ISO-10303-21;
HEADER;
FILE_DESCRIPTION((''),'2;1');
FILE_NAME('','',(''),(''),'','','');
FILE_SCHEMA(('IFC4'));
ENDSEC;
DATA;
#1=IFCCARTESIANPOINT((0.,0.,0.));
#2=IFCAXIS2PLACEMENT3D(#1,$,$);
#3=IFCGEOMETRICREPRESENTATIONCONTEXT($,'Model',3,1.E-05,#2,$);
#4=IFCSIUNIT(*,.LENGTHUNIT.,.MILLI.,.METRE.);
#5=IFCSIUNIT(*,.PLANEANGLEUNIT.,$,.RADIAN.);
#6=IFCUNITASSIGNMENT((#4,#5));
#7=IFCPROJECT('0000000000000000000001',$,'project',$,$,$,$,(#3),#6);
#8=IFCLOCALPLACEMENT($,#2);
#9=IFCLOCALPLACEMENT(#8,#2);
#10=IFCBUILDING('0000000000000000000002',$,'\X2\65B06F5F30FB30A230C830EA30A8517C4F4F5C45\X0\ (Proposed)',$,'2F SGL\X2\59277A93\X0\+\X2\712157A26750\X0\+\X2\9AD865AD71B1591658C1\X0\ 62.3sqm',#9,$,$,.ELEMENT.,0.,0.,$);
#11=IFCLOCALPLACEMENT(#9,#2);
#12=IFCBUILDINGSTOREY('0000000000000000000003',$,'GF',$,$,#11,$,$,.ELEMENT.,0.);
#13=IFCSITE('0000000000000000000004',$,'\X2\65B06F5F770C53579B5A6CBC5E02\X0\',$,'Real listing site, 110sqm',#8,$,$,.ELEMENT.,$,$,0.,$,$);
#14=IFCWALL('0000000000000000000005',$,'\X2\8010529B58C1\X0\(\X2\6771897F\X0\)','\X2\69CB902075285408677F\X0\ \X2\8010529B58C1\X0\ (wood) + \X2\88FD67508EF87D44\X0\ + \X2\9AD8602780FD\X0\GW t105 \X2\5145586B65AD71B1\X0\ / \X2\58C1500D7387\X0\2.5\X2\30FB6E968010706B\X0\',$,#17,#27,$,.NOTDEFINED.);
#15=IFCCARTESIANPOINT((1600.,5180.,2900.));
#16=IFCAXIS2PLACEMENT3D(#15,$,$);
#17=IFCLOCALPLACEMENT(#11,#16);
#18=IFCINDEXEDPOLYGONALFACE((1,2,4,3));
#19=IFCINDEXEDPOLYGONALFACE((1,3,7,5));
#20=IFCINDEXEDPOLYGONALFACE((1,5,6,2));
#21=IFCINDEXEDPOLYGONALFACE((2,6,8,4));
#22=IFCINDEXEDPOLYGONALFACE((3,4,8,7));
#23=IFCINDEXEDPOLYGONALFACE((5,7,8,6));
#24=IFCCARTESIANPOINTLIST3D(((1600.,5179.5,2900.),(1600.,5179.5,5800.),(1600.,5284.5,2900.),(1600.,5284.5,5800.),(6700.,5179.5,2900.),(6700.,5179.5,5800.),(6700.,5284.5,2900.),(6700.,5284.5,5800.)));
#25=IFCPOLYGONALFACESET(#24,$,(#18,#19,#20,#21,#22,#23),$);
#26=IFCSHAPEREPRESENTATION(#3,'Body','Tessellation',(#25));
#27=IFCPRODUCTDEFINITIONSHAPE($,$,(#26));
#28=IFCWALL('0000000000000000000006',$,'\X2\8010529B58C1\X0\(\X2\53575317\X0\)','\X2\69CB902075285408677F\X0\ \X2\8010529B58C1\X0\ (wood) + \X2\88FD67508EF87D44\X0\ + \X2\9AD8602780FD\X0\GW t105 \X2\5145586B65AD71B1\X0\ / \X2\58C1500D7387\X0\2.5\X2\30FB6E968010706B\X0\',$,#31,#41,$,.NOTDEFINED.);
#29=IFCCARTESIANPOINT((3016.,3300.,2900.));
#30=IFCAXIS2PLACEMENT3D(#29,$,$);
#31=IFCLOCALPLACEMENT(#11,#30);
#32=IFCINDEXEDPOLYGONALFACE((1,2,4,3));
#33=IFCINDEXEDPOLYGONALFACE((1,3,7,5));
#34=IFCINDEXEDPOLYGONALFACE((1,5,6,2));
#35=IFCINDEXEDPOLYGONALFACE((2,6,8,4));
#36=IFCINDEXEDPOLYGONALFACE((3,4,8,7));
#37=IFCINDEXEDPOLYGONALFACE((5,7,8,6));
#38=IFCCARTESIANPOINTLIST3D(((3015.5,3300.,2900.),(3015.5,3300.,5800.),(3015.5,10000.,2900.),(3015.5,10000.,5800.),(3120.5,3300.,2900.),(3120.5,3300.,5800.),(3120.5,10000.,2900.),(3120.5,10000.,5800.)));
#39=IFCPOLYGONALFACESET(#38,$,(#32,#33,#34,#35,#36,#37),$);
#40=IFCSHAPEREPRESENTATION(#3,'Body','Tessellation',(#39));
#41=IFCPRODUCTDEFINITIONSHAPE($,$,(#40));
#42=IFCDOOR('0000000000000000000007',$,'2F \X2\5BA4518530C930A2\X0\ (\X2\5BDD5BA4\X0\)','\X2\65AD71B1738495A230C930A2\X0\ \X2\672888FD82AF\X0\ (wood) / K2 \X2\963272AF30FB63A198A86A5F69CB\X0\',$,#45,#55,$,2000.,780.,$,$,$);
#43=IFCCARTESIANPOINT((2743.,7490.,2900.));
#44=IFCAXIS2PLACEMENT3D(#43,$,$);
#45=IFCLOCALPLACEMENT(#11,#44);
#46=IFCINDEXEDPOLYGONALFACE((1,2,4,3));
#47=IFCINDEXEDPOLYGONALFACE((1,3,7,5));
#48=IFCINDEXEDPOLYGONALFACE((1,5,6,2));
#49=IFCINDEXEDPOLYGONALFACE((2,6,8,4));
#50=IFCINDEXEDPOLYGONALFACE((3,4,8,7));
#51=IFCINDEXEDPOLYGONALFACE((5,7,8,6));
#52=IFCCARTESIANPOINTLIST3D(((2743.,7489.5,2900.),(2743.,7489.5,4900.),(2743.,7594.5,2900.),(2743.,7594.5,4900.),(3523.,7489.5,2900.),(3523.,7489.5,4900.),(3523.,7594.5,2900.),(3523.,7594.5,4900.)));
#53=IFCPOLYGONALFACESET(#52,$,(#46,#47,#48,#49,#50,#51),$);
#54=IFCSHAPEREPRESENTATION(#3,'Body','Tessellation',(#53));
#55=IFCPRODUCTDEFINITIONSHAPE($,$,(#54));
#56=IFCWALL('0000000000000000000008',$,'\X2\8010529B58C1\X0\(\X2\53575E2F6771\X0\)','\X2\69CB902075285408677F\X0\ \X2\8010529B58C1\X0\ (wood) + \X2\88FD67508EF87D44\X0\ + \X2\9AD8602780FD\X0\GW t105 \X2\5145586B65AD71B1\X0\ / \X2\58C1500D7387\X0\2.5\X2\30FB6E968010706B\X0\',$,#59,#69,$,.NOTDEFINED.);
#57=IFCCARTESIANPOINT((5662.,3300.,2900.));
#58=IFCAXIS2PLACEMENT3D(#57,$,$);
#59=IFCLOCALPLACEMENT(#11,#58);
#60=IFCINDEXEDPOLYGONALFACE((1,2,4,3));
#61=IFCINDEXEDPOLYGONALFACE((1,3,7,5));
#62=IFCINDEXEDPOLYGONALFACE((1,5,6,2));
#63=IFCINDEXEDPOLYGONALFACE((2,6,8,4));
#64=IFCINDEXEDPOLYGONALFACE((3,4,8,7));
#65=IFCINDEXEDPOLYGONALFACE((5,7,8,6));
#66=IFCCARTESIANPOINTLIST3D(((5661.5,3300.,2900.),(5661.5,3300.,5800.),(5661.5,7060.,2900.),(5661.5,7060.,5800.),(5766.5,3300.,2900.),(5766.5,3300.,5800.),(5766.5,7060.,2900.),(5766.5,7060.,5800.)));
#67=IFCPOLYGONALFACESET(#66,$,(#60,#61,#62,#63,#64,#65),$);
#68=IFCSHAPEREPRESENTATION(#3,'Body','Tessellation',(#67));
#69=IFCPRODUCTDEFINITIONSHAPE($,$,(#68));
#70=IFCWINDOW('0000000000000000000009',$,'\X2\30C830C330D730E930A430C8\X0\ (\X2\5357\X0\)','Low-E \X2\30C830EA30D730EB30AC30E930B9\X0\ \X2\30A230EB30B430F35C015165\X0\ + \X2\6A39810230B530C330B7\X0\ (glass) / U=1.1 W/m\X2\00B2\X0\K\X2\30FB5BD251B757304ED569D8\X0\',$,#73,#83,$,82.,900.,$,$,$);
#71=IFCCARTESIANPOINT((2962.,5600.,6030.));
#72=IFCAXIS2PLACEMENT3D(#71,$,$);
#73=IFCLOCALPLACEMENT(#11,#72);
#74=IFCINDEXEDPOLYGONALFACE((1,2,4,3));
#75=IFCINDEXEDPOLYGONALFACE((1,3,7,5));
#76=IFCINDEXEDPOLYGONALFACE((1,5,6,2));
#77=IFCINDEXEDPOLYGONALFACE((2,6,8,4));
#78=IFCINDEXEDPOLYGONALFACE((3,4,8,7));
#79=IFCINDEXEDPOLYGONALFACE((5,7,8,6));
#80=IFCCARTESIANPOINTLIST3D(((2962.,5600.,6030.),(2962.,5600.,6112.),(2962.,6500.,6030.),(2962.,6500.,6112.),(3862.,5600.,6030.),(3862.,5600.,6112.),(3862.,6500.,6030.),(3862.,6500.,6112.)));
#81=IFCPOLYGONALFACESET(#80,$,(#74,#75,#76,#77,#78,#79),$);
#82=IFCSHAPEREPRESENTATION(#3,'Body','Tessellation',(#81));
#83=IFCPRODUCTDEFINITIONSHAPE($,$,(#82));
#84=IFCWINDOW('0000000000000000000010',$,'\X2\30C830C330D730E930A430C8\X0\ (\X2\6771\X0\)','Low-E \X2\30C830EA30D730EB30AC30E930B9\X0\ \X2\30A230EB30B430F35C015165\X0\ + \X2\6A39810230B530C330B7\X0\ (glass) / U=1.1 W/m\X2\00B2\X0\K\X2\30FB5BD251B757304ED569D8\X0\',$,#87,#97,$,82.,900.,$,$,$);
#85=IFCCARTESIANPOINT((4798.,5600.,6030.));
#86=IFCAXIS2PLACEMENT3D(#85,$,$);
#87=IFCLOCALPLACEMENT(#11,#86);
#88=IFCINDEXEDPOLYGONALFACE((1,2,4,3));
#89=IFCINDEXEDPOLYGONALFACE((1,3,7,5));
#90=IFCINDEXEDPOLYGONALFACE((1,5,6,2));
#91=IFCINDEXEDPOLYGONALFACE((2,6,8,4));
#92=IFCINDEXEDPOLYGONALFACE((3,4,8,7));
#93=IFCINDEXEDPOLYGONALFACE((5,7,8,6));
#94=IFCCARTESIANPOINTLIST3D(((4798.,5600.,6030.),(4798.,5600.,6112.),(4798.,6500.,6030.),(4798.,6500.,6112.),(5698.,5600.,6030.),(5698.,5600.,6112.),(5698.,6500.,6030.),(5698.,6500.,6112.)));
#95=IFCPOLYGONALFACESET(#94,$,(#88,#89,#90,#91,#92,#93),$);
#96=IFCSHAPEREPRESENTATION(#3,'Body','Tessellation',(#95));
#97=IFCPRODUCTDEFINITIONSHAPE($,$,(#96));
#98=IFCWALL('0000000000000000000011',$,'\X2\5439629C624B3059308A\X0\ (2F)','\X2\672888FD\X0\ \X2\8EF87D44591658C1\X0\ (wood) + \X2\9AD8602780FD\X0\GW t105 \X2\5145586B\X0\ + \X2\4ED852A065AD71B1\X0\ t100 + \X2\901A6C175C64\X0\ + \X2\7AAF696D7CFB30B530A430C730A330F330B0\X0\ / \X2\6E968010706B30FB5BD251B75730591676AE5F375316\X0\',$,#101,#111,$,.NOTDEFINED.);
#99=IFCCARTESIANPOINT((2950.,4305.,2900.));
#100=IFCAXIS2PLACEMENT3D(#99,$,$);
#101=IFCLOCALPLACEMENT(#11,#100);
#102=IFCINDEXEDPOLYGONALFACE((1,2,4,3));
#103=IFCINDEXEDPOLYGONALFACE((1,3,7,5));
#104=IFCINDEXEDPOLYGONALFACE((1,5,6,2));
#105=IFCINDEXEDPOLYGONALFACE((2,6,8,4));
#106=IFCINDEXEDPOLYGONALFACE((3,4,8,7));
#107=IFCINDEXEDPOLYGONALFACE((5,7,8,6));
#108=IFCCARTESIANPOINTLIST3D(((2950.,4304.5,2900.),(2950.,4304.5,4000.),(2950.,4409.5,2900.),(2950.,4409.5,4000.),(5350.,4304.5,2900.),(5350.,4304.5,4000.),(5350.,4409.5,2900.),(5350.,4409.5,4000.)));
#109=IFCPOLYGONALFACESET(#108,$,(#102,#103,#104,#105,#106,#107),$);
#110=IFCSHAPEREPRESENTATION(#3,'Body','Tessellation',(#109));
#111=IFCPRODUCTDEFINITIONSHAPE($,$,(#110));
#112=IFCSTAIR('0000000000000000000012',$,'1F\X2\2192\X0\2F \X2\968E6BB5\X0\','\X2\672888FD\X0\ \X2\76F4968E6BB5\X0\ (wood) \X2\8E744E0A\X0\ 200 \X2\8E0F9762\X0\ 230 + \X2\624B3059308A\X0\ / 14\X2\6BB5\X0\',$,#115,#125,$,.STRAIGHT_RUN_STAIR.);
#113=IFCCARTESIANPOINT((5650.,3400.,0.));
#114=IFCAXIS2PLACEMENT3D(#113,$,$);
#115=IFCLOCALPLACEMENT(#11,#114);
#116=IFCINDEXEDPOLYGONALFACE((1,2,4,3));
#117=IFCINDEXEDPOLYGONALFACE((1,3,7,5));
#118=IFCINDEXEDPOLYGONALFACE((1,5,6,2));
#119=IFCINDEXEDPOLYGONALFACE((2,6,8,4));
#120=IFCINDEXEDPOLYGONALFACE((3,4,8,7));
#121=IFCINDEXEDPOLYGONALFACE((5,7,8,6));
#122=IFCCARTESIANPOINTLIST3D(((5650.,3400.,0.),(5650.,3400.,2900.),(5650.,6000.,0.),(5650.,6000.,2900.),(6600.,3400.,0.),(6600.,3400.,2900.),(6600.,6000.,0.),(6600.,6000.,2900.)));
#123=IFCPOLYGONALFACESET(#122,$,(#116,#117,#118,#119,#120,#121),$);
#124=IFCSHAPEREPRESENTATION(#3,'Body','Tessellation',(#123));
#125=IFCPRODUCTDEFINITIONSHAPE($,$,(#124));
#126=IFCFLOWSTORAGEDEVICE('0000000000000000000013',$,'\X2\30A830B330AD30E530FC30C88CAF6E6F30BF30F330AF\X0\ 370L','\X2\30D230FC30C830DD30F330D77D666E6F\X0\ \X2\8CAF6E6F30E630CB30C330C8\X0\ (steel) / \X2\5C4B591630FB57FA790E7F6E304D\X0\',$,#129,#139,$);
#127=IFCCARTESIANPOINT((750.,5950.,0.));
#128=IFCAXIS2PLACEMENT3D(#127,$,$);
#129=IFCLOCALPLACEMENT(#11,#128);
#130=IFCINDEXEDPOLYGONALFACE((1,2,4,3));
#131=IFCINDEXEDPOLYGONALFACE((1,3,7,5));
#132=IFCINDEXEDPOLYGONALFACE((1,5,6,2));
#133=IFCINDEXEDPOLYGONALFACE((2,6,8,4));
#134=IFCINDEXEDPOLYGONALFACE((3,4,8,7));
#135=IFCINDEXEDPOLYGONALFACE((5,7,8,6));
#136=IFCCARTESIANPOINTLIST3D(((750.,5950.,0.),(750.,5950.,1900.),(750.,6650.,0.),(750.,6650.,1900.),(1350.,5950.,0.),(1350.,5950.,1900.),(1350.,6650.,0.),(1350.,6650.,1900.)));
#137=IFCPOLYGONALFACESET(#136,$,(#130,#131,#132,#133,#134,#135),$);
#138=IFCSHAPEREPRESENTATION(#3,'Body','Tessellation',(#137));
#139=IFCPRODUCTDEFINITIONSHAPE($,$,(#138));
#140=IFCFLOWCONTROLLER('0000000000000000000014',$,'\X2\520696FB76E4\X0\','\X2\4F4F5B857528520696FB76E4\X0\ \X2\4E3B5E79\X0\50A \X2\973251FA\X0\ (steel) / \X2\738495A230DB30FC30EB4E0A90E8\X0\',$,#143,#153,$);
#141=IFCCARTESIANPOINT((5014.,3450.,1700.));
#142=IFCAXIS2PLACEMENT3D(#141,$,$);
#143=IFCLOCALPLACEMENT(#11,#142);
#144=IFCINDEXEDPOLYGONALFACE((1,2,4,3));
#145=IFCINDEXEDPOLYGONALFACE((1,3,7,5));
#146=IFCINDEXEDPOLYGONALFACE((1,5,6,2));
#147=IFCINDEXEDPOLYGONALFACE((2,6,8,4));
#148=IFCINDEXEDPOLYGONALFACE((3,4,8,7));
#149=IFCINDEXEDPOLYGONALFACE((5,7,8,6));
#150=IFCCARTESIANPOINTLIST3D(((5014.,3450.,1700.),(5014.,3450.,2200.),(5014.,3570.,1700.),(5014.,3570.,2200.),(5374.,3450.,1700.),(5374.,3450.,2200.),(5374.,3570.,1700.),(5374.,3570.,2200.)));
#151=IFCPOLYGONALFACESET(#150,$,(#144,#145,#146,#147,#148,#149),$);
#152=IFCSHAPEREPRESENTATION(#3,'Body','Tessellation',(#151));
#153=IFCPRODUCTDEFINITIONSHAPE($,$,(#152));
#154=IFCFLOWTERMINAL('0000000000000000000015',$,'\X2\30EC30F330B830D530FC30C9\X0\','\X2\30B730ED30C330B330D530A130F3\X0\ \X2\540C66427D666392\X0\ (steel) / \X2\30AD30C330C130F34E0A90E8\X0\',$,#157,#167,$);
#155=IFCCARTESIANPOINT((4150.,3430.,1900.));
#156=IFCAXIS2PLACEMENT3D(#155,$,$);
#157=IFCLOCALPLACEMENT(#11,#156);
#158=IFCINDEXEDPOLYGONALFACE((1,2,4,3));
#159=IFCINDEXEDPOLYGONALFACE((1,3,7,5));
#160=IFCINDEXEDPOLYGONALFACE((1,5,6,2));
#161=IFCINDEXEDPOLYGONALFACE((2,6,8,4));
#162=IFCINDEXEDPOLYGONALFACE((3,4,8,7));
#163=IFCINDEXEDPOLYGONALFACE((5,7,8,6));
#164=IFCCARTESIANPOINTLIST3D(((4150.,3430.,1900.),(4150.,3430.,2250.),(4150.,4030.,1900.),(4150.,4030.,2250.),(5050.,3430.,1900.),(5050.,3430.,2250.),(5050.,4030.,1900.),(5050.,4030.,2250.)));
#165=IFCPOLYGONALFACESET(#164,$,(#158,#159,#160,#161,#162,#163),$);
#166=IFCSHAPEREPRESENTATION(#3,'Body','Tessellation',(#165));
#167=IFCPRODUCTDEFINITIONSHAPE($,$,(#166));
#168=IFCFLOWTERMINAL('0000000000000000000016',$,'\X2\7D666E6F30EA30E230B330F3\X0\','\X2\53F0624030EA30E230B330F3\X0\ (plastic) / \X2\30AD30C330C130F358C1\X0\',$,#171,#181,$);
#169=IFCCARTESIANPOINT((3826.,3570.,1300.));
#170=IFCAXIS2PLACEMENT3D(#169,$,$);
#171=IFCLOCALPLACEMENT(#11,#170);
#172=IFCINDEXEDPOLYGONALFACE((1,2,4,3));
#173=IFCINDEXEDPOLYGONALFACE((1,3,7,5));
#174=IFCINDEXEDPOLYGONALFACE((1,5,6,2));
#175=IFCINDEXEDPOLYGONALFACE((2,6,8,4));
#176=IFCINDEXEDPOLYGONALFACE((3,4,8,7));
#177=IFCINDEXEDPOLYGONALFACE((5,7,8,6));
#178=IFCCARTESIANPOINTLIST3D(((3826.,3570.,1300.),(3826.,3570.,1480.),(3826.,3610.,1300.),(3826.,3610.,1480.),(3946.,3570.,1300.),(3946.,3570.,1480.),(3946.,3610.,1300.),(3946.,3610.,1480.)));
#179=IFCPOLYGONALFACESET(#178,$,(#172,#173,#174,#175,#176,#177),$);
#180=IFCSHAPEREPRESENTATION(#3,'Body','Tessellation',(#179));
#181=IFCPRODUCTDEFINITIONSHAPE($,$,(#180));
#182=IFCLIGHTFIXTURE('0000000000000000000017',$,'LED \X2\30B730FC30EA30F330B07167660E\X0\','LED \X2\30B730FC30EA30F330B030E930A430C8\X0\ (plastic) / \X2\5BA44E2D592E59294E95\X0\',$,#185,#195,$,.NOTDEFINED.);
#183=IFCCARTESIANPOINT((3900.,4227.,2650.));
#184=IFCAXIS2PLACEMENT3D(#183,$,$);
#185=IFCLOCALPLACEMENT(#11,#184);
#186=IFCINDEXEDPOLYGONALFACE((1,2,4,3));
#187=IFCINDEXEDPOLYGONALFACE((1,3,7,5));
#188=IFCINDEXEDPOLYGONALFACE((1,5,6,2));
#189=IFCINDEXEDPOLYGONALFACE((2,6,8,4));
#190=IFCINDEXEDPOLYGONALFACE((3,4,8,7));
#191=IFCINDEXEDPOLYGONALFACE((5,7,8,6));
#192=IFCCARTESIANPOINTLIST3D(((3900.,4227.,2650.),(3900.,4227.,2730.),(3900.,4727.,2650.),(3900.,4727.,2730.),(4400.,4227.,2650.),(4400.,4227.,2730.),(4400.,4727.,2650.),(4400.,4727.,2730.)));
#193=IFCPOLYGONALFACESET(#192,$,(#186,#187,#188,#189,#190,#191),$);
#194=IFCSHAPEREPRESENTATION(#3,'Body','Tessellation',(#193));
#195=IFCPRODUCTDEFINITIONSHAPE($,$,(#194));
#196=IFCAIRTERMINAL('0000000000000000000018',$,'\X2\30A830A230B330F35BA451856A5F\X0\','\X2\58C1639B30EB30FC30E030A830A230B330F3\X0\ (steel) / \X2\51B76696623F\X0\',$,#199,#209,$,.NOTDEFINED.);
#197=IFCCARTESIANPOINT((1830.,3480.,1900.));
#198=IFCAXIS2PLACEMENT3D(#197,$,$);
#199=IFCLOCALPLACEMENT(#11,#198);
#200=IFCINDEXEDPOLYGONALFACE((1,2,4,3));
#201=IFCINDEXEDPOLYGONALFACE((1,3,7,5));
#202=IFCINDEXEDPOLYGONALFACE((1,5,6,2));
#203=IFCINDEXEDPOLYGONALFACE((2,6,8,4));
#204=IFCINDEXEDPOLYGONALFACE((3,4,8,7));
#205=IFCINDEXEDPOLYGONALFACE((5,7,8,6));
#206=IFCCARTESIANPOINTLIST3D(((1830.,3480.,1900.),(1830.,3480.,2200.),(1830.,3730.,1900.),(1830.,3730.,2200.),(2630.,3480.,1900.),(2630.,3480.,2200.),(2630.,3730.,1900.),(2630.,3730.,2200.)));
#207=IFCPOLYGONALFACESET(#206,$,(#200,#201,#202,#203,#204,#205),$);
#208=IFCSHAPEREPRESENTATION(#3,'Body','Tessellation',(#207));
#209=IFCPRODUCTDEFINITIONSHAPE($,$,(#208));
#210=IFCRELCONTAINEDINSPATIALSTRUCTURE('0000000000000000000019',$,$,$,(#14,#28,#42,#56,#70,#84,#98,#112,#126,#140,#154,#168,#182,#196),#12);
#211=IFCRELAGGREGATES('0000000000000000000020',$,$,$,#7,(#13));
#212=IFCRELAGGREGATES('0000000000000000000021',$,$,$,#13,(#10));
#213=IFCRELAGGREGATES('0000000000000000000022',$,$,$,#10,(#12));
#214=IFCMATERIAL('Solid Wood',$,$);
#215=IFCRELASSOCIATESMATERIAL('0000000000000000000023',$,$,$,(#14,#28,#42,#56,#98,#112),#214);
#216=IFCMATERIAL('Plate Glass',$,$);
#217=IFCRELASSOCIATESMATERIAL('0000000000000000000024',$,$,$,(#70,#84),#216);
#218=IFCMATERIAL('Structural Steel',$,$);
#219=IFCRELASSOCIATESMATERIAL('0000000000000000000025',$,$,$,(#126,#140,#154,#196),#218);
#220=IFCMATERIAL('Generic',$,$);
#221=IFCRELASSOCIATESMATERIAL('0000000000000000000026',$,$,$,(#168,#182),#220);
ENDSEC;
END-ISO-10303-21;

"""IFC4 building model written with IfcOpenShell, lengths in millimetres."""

from ifc_helpers import new_model, si_unit, frame, frame_2d, origin, place, context, project, spatial, rectangle, extrude, material, element, fill, save


model = new_model("IFC4")

# Units and contexts
model_context = context("Model", 3, precision=1e-05, world=origin())
ifc_project = project(units=[si_unit("LENGTHUNIT", "METRE", prefix="MILLI"), si_unit("PLANEANGLEUNIT", "RADIAN")], contexts=[model_context])

# Site, building, storey
site_placement = place(None, origin())
site = spatial("IfcSite", under=ifc_project, at=site_placement, Name="新潟県南魚沼市", ObjectType="Real listing site, 110sqm", CompositionType="ELEMENT", RefElevation=0.0)
building_placement = place(site_placement, origin())
building = spatial("IfcBuilding", under=site, at=building_placement, Name="新潟・アトリエ兼住居 (Proposed)", ObjectType="2F SGL大窓+無垢材+高断熱外壁 62.3sqm", CompositionType="ELEMENT", ElevationOfRefHeight=0.0, ElevationOfTerrain=0.0)
storey_placement = place(building_placement, origin())
storey = spatial("IfcBuildingStorey", under=building, at=storey_placement, Name="GF", CompositionType="ELEMENT", Elevation=0.0)

# Shared definitions
ifc_material_1 = material(Name="Solid Wood")

# Wall
wall_1_placement = place(storey_placement, frame((1600.0, 5180.0, 2900.0)))
element("IfcWall", 1, at=wall_1_placement, inside=storey, material=ifc_material_1, Name="耐力壁(東西)", Description="構造用合板 耐力壁 (wood) + 製材軸組 + 高性能GW t105 充填断熱 / 壁倍率2.5・準耐火", PredefinedType="NOTDEFINED", context=model_context, shape_type="SweptSolid", body=[
    extrude(rectangle(XDim=5100.0, YDim=105.0, at=frame_2d((2550.0, 52.0))), frame((1600.0, 5180.0, 2900.0)), (0.0, 0.0, 1.0), 2900.0),
])

# Wall, opening, door
wall_2_placement = place(storey_placement, frame((3016.0, 3300.0, 2900.0)))
wall_2 = element("IfcWall", 2, at=wall_2_placement, inside=storey, material=ifc_material_1, Name="耐力壁(南北)", Description="構造用合板 耐力壁 (wood) + 製材軸組 + 高性能GW t105 充填断熱 / 壁倍率2.5・準耐火", PredefinedType="NOTDEFINED", context=model_context, shape_type="SweptSolid", body=[
    extrude(rectangle(XDim=105.0, YDim=6700.0, at=frame_2d((52.0, 3350.0))), frame((3016.0, 3300.0, 2900.0)), (0.0, 0.0, 1.0), 2900.0),
])
opening_placement = place(storey_placement, frame((2743.0, 7490.0, 2900.0)))
opening = element("IfcOpeningElement", 3, at=opening_placement, cuts=wall_2, PredefinedType="NOTDEFINED", context=model_context, shape_type="SweptSolid", body=[
    extrude(rectangle(XDim=780.0, YDim=105.0, at=frame_2d((390.0, 52.0))), frame((2743.0, 7490.0, 2900.0)), (0.0, 0.0, 1.0), 2000.0),
])
door_placement = place(storey_placement, frame((2743.0, 7490.0, 2900.0)))
door = element("IfcDoor", 4, at=door_placement, inside=storey, material=ifc_material_1, Name="2F 室内ドア (寝室)", Description="断熱玄関ドア 木製芯 (wood) / K2 防犯・採風機構", OverallHeight=2000.0, OverallWidth=780.0, context=model_context, shape_type="SweptSolid", body=[
    extrude(rectangle(XDim=780.0, YDim=105.0, at=frame_2d((390.0, 52.0))), frame((2743.0, 7490.0, 2900.0)), (0.0, 0.0, 1.0), 2000.0),
])
fill(opening, door)

# Wall
wall_3_placement = place(storey_placement, frame((5662.0, 3300.0, 2900.0)))
element("IfcWall", 5, at=wall_3_placement, inside=storey, material=ifc_material_1, Name="耐力壁(南帯東)", Description="構造用合板 耐力壁 (wood) + 製材軸組 + 高性能GW t105 充填断熱 / 壁倍率2.5・準耐火", PredefinedType="NOTDEFINED", context=model_context, shape_type="SweptSolid", body=[
    extrude(rectangle(XDim=105.0, YDim=3760.0, at=frame_2d((52.0, 1880.0))), frame((5662.0, 3300.0, 2900.0)), (0.0, 0.0, 1.0), 2900.0),
])

# Windows
ifc_material_2 = material(Name="Plate Glass")
window_1_placement = place(storey_placement, frame((2962.0, 5600.0, 6030.0)))
element("IfcWindow", 6, at=window_1_placement, inside=storey, material=ifc_material_2, Name="トップライト (南)", Description="Low-E トリプルガラス アルゴン封入 + 樹脂サッシ (glass) / U=1.1 W/m²K・寒冷地仕様", OverallHeight=82.0, OverallWidth=900.0, context=model_context, shape_type="SweptSolid", body=[
    extrude(rectangle(XDim=900.0, YDim=900.0, at=frame_2d((450.0, 450.0))), frame((2962.0, 5600.0, 6030.0)), (0.0, 0.0, 1.0), 82.0),
])
window_2_placement = place(storey_placement, frame((4798.0, 5600.0, 6030.0)))
element("IfcWindow", 7, at=window_2_placement, inside=storey, material=ifc_material_2, Name="トップライト (東)", Description="Low-E トリプルガラス アルゴン封入 + 樹脂サッシ (glass) / U=1.1 W/m²K・寒冷地仕様", OverallHeight=82.0, OverallWidth=900.0, context=model_context, shape_type="SweptSolid", body=[
    extrude(rectangle(XDim=900.0, YDim=900.0, at=frame_2d((450.0, 450.0))), frame((4798.0, 5600.0, 6030.0)), (0.0, 0.0, 1.0), 82.0),
])

# Wall
wall_4_placement = place(storey_placement, frame((2950.0, 4305.0, 2900.0)))
element("IfcWall", 8, at=wall_4_placement, inside=storey, material=ifc_material_1, Name="吹抜手すり (2F)", Description="木製 軸組外壁 (wood) + 高性能GW t105 充填 + 付加断熱 t100 + 通気層 + 窯業系サイディング / 準耐火・寒冷地外皮強化", PredefinedType="NOTDEFINED", context=model_context, shape_type="SweptSolid", body=[
    extrude(rectangle(XDim=2400.0, YDim=105.0, at=frame_2d((1200.0, 52.0))), frame((2950.0, 4305.0, 2900.0)), (0.0, 0.0, 1.0), 1100.0),
])

# Stair
stair_placement = place(storey_placement, frame((5650.0, 3400.0, 0.0)))
element("IfcStair", 9, at=stair_placement, inside=storey, material=ifc_material_1, Name="1F→2F 階段", Description="木製 直階段 (wood) 蹴上 200 踏面 230 + 手すり / 14段", PredefinedType="STRAIGHT_RUN_STAIR", context=model_context, shape_type="SweptSolid", body=[
    extrude(rectangle(XDim=950.0, YDim=2600.0, at=frame_2d((475.0, 1300.0))), frame((5650.0, 3400.0, 0.0)), (0.0, 0.0, 1.0), 2900.0),
])

# Flow storage device
ifc_material_3 = material(Name="Structural Steel")
flow_storage_device_placement = place(storey_placement, frame((750.0, 5950.0, 0.0)))
element("IfcFlowStorageDevice", 10, at=flow_storage_device_placement, inside=storey, material=ifc_material_3, Name="エコキュート貯湯タンク 370L", Description="ヒートポンプ給湯 貯湯ユニット (steel) / 屋外・基礎置き", context=model_context, shape_type="SweptSolid", body=[
    extrude(rectangle(XDim=600.0, YDim=700.0, at=frame_2d((300.0, 350.0))), frame((750.0, 5950.0, 0.0)), (0.0, 0.0, 1.0), 1900.0),
])

# Flow controller
flow_controller_placement = place(storey_placement, frame((5014.0, 3450.0, 1700.0)))
element("IfcFlowController", 11, at=flow_controller_placement, inside=storey, material=ifc_material_3, Name="分電盤", Description="住宅用分電盤 主幹50A 露出 (steel) / 玄関ホール上部", context=model_context, shape_type="SweptSolid", body=[
    extrude(rectangle(XDim=360.0, YDim=120.0, at=frame_2d((180.0, 60.0))), frame((5014.0, 3450.0, 1700.0)), (0.0, 0.0, 1.0), 500.0),
])

# Flow terminals
flow_terminal_1_placement = place(storey_placement, frame((4150.0, 3430.0, 1900.0)))
element("IfcFlowTerminal", 12, at=flow_terminal_1_placement, inside=storey, material=ifc_material_3, Name="レンジフード", Description="シロッコファン 同時給排 (steel) / キッチン上部", context=model_context, shape_type="SweptSolid", body=[
    extrude(rectangle(XDim=900.0, YDim=600.0, at=frame_2d((450.0, 300.0))), frame((4150.0, 3430.0, 1900.0)), (0.0, 0.0, 1.0), 350.0),
])
ifc_material_4 = material(Name="Generic")
flow_terminal_2_placement = place(storey_placement, frame((3826.0, 3570.0, 1300.0)))
element("IfcFlowTerminal", 13, at=flow_terminal_2_placement, inside=storey, material=ifc_material_4, Name="給湯リモコン", Description="台所リモコン (plastic) / キッチン壁", context=model_context, shape_type="SweptSolid", body=[
    extrude(rectangle(XDim=120.0, YDim=40.0, at=frame_2d((60.0, 20.0))), frame((3826.0, 3570.0, 1300.0)), (0.0, 0.0, 1.0), 180.0),
])

# Light fixture
light_fixture_1_placement = place(storey_placement, frame((3900.0, 4227.0, 2650.0)))
element("IfcLightFixture", 14, at=light_fixture_1_placement, inside=storey, material=ifc_material_4, Name="LED シーリング照明", Description="LED シーリングライト (plastic) / 室中央天井", PredefinedType="NOTDEFINED", context=model_context, shape_type="SweptSolid", body=[
    extrude(rectangle(XDim=500.0, YDim=500.0, at=frame_2d((250.0, 250.0))), frame((3900.0, 4227.0, 2650.0)), (0.0, 0.0, 1.0), 80.0),
])

# Air terminal
air_terminal_1_placement = place(storey_placement, frame((1830.0, 3480.0, 1900.0)))
element("IfcAirTerminal", 15, at=air_terminal_1_placement, inside=storey, material=ifc_material_3, Name="エアコン室内機", Description="壁掛ルームエアコン (steel) / 冷暖房", PredefinedType="NOTDEFINED", context=model_context, shape_type="SweptSolid", body=[
    extrude(rectangle(XDim=800.0, YDim=250.0, at=frame_2d((400.0, 125.0))), frame((1830.0, 3480.0, 1900.0)), (0.0, 0.0, 1.0), 300.0),
])

save(model, "model.ifc")
